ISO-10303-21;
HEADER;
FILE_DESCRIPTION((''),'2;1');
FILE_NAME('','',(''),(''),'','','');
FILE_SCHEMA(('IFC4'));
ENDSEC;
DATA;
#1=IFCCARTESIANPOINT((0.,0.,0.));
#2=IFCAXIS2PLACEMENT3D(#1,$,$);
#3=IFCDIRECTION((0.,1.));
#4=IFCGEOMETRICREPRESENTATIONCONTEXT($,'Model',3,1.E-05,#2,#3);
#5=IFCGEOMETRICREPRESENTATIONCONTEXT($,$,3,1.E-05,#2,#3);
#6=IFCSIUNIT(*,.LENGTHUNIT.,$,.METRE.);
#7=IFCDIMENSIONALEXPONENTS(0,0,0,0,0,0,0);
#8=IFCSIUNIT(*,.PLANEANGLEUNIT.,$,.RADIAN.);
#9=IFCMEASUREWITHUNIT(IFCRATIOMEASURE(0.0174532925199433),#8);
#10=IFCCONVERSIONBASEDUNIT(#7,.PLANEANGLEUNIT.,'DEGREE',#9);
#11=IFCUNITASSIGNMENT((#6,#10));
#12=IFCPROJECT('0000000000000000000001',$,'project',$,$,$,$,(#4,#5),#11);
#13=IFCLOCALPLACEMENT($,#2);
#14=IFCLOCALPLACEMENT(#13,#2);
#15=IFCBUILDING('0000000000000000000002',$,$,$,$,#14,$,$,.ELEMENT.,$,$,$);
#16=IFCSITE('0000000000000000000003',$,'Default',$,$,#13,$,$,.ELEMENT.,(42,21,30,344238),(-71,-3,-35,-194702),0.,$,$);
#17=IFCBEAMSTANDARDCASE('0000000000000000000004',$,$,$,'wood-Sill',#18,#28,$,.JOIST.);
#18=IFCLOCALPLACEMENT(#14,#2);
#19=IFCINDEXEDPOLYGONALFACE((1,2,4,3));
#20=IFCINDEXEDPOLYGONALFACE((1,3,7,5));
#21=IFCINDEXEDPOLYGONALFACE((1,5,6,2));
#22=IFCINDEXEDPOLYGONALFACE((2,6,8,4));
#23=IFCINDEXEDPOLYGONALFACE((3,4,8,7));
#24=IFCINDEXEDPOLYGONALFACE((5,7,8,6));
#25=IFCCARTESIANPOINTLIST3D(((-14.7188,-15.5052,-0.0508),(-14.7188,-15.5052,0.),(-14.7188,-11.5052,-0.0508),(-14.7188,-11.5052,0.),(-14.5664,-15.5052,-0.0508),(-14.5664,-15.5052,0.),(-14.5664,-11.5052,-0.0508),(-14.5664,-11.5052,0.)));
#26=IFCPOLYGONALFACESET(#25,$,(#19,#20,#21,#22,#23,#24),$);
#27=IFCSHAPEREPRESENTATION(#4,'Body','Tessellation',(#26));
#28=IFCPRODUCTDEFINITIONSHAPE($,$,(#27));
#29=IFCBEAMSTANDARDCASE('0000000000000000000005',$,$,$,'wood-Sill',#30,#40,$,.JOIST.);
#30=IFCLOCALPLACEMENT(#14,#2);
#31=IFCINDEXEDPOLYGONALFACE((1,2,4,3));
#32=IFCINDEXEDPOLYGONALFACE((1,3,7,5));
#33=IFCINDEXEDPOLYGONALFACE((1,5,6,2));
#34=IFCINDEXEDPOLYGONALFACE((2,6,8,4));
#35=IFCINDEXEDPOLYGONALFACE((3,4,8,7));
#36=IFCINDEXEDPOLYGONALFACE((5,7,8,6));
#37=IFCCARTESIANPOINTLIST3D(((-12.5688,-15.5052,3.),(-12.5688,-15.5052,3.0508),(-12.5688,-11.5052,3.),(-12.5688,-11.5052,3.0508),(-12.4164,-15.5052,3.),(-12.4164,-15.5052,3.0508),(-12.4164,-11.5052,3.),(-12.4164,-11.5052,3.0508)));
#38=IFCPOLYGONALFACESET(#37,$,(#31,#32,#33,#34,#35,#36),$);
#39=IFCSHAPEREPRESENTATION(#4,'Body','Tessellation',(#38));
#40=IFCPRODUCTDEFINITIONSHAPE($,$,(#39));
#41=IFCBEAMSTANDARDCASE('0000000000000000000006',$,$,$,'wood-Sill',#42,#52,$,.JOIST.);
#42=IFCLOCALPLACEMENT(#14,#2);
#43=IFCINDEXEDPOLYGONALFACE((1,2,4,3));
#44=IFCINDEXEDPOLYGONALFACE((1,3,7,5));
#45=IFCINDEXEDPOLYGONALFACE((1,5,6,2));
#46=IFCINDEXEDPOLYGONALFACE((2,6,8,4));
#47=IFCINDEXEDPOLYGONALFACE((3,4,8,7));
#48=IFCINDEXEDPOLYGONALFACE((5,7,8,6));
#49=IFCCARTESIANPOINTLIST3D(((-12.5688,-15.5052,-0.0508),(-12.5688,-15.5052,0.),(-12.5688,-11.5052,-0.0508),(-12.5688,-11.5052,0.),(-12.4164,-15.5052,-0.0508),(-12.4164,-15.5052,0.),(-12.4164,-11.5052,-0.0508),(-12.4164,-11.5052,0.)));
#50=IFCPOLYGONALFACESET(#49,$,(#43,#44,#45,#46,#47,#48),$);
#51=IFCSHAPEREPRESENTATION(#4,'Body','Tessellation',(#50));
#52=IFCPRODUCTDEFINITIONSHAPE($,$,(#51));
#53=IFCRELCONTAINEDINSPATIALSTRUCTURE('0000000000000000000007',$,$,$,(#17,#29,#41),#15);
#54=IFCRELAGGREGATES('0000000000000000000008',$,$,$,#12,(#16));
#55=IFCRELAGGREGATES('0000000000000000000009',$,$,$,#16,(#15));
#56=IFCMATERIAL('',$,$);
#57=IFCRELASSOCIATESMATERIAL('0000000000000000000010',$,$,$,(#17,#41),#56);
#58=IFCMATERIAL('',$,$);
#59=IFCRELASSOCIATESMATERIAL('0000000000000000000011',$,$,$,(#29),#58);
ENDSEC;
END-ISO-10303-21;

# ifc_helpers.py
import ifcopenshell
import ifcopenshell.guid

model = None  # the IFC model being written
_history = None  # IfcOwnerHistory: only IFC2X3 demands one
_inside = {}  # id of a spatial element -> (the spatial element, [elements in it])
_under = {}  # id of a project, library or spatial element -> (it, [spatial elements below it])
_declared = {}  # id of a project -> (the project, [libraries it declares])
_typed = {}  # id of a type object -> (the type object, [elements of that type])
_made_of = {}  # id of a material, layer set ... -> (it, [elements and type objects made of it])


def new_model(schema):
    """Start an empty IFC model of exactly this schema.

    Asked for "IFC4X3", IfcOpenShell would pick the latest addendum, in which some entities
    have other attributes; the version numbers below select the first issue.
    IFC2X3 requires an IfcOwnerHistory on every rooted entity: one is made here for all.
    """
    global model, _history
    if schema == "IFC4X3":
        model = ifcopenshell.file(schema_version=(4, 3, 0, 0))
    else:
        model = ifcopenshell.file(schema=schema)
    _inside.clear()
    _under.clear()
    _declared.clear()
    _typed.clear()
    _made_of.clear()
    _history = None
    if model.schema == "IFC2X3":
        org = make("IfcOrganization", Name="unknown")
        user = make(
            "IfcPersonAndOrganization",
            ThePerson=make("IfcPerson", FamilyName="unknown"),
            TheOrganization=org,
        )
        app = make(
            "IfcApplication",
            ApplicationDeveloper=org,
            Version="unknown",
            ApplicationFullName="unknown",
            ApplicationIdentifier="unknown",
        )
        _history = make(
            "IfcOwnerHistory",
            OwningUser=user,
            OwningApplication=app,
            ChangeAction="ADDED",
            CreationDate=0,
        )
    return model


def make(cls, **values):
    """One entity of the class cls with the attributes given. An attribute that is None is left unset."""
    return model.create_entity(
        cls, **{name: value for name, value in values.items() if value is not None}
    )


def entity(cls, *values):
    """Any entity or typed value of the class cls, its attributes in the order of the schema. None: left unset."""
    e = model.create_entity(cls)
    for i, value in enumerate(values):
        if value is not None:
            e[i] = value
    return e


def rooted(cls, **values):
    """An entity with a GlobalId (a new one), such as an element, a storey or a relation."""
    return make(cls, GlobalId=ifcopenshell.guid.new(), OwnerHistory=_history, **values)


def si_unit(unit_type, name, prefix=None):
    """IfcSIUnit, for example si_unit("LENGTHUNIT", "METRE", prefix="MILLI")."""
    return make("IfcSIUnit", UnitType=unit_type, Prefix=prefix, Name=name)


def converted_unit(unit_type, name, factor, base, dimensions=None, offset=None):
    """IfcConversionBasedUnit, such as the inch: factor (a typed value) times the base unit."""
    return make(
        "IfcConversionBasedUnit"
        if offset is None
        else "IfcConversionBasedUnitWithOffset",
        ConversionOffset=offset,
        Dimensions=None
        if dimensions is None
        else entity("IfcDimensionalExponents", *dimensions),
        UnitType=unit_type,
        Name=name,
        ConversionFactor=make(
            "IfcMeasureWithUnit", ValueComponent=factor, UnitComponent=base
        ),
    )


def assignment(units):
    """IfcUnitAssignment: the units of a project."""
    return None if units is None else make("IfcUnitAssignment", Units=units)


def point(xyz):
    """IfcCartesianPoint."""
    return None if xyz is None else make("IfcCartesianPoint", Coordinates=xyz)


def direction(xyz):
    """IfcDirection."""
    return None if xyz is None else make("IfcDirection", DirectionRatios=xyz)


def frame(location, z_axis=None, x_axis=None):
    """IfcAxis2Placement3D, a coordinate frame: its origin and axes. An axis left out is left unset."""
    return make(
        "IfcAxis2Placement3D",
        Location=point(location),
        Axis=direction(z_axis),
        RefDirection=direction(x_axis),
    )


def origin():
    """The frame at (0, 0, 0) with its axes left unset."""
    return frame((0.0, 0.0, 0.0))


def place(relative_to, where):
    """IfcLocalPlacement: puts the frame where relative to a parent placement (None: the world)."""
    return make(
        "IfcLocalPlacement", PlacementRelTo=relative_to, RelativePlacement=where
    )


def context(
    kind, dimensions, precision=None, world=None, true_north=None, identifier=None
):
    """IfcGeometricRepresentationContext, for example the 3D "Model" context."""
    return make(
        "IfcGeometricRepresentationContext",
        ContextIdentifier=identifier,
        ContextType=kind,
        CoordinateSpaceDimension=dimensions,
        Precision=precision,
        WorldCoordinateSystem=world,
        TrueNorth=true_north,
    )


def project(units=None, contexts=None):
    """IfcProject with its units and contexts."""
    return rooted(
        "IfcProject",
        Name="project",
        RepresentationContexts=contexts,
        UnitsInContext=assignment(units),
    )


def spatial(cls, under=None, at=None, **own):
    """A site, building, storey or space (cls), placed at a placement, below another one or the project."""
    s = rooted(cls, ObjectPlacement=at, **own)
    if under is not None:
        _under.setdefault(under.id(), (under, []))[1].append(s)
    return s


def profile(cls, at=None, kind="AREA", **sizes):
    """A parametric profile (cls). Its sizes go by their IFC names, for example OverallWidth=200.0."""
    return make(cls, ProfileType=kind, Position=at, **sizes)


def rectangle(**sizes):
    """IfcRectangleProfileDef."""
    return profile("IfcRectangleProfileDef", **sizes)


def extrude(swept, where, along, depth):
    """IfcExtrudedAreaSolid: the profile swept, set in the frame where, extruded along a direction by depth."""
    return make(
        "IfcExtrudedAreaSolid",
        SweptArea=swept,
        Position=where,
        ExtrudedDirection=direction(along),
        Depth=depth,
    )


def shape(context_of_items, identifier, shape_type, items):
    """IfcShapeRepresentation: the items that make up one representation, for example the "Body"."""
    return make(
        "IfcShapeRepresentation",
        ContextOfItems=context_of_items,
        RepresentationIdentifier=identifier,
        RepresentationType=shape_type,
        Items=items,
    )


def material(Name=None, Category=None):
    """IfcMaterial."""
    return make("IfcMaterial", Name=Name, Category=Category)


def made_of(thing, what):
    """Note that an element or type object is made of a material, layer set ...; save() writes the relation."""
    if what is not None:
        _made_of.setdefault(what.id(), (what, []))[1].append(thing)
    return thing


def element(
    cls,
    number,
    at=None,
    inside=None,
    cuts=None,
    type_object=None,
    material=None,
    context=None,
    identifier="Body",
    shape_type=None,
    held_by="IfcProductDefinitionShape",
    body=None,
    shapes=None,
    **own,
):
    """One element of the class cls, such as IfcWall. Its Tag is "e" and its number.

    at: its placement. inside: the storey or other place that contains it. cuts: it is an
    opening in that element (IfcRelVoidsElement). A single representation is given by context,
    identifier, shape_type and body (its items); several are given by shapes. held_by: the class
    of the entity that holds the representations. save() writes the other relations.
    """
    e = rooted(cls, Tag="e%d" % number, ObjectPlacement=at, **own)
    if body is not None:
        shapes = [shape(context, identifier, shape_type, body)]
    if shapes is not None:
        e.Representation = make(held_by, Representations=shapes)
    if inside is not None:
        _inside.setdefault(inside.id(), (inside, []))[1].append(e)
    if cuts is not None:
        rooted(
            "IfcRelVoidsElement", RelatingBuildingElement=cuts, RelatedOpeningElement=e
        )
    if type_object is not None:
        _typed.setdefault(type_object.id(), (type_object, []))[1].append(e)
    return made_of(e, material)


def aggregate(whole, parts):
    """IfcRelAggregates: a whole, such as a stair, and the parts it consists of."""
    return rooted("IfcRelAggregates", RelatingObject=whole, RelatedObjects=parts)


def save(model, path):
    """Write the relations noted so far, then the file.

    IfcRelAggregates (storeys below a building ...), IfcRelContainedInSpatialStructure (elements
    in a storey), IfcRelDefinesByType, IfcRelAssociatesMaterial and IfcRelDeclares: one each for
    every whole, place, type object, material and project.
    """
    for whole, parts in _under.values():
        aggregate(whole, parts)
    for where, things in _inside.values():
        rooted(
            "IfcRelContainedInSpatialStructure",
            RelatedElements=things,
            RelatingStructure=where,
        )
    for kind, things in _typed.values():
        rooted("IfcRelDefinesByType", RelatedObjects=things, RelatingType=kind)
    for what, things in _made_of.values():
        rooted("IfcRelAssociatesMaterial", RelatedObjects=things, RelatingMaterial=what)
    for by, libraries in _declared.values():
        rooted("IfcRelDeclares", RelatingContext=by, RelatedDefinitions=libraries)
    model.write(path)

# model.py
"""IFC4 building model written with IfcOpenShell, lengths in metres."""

from ifc_helpers import new_model, entity, si_unit, converted_unit, direction, frame, origin, place, context, project, spatial, rectangle, extrude, material, element, save


model = new_model("IFC4")

# Units and contexts
model_context = context("Model", 3, precision=1e-05, world=origin(), true_north=direction((0.0, 1.0)))
context_of_model = context(None, 3, precision=1e-05, world=origin(), true_north=direction((0.0, 1.0)))
ifc_project = project(units=[si_unit("LENGTHUNIT", "METRE"), converted_unit("PLANEANGLEUNIT", "DEGREE", entity("IfcRatioMeasure", 0.0174532925199433), si_unit("PLANEANGLEUNIT", "RADIAN"), dimensions=[0, 0, 0, 0, 0, 0, 0])], contexts=[model_context, context_of_model])

# Site, building
site_placement = place(None, origin())
site = spatial("IfcSite", under=ifc_project, at=site_placement, Name="Default", CompositionType="ELEMENT", RefLatitude=(42, 21, 30, 344238), RefLongitude=(-71, -3, -35, -194702), RefElevation=0.0)
building_placement = place(site_placement, origin())
building = spatial("IfcBuilding", under=site, at=building_placement, CompositionType="ELEMENT")

# Shared definitions
placement_1 = place(building_placement, origin())
placement_2 = place(placement_1, frame((-14.6426, -15.5052, 0.0), z_axis=(0.0, 0.0, 1.0), x_axis=(0.0, 1.0, 0.0)))
placement_3 = place(placement_1, frame((-12.4926, -15.5052, 0.0), z_axis=(0.0, 0.0, 1.0), x_axis=(0.0, 1.0, 0.0)))

# Beams
ifc_material_1 = material(Name="")
beam_1_placement = place(placement_2, frame((2.0, 0.0, -0.0508), z_axis=(0.0, 0.0, 1.0), x_axis=(1.0, 0.0, 0.0)))
element("IfcBeamStandardCase", 1, at=beam_1_placement, inside=building, material=ifc_material_1, ObjectType="wood-Sill", PredefinedType="JOIST", context=model_context, shape_type="SweptSolid", body=[
    extrude(rectangle(XDim=4.0, YDim=0.1524), origin(), (0.0, 0.0, 1.0), 0.0508),
])
ifc_material_2 = material(Name="")
beam_2_placement = place(placement_3, frame((2.0, 0.0, 3.0), z_axis=(0.0, 0.0, 1.0), x_axis=(1.0, 0.0, 0.0)))
element("IfcBeamStandardCase", 2, at=beam_2_placement, inside=building, material=ifc_material_2, ObjectType="wood-Sill", PredefinedType="JOIST", context=model_context, shape_type="SweptSolid", body=[
    extrude(rectangle(XDim=4.0, YDim=0.1524), origin(), (0.0, 0.0, 1.0), 0.0508),
])
beam_3_placement = place(placement_3, frame((2.0, 0.0, -0.0508), z_axis=(0.0, 0.0, 1.0), x_axis=(1.0, 0.0, 0.0)))
element("IfcBeamStandardCase", 3, at=beam_3_placement, inside=building, material=ifc_material_1, ObjectType="wood-Sill", PredefinedType="JOIST", context=model_context, shape_type="SweptSolid", body=[
    extrude(rectangle(XDim=4.0, YDim=0.1524), origin(), (0.0, 0.0, 1.0), 0.0508),
])

save(model, "model.ifc")
